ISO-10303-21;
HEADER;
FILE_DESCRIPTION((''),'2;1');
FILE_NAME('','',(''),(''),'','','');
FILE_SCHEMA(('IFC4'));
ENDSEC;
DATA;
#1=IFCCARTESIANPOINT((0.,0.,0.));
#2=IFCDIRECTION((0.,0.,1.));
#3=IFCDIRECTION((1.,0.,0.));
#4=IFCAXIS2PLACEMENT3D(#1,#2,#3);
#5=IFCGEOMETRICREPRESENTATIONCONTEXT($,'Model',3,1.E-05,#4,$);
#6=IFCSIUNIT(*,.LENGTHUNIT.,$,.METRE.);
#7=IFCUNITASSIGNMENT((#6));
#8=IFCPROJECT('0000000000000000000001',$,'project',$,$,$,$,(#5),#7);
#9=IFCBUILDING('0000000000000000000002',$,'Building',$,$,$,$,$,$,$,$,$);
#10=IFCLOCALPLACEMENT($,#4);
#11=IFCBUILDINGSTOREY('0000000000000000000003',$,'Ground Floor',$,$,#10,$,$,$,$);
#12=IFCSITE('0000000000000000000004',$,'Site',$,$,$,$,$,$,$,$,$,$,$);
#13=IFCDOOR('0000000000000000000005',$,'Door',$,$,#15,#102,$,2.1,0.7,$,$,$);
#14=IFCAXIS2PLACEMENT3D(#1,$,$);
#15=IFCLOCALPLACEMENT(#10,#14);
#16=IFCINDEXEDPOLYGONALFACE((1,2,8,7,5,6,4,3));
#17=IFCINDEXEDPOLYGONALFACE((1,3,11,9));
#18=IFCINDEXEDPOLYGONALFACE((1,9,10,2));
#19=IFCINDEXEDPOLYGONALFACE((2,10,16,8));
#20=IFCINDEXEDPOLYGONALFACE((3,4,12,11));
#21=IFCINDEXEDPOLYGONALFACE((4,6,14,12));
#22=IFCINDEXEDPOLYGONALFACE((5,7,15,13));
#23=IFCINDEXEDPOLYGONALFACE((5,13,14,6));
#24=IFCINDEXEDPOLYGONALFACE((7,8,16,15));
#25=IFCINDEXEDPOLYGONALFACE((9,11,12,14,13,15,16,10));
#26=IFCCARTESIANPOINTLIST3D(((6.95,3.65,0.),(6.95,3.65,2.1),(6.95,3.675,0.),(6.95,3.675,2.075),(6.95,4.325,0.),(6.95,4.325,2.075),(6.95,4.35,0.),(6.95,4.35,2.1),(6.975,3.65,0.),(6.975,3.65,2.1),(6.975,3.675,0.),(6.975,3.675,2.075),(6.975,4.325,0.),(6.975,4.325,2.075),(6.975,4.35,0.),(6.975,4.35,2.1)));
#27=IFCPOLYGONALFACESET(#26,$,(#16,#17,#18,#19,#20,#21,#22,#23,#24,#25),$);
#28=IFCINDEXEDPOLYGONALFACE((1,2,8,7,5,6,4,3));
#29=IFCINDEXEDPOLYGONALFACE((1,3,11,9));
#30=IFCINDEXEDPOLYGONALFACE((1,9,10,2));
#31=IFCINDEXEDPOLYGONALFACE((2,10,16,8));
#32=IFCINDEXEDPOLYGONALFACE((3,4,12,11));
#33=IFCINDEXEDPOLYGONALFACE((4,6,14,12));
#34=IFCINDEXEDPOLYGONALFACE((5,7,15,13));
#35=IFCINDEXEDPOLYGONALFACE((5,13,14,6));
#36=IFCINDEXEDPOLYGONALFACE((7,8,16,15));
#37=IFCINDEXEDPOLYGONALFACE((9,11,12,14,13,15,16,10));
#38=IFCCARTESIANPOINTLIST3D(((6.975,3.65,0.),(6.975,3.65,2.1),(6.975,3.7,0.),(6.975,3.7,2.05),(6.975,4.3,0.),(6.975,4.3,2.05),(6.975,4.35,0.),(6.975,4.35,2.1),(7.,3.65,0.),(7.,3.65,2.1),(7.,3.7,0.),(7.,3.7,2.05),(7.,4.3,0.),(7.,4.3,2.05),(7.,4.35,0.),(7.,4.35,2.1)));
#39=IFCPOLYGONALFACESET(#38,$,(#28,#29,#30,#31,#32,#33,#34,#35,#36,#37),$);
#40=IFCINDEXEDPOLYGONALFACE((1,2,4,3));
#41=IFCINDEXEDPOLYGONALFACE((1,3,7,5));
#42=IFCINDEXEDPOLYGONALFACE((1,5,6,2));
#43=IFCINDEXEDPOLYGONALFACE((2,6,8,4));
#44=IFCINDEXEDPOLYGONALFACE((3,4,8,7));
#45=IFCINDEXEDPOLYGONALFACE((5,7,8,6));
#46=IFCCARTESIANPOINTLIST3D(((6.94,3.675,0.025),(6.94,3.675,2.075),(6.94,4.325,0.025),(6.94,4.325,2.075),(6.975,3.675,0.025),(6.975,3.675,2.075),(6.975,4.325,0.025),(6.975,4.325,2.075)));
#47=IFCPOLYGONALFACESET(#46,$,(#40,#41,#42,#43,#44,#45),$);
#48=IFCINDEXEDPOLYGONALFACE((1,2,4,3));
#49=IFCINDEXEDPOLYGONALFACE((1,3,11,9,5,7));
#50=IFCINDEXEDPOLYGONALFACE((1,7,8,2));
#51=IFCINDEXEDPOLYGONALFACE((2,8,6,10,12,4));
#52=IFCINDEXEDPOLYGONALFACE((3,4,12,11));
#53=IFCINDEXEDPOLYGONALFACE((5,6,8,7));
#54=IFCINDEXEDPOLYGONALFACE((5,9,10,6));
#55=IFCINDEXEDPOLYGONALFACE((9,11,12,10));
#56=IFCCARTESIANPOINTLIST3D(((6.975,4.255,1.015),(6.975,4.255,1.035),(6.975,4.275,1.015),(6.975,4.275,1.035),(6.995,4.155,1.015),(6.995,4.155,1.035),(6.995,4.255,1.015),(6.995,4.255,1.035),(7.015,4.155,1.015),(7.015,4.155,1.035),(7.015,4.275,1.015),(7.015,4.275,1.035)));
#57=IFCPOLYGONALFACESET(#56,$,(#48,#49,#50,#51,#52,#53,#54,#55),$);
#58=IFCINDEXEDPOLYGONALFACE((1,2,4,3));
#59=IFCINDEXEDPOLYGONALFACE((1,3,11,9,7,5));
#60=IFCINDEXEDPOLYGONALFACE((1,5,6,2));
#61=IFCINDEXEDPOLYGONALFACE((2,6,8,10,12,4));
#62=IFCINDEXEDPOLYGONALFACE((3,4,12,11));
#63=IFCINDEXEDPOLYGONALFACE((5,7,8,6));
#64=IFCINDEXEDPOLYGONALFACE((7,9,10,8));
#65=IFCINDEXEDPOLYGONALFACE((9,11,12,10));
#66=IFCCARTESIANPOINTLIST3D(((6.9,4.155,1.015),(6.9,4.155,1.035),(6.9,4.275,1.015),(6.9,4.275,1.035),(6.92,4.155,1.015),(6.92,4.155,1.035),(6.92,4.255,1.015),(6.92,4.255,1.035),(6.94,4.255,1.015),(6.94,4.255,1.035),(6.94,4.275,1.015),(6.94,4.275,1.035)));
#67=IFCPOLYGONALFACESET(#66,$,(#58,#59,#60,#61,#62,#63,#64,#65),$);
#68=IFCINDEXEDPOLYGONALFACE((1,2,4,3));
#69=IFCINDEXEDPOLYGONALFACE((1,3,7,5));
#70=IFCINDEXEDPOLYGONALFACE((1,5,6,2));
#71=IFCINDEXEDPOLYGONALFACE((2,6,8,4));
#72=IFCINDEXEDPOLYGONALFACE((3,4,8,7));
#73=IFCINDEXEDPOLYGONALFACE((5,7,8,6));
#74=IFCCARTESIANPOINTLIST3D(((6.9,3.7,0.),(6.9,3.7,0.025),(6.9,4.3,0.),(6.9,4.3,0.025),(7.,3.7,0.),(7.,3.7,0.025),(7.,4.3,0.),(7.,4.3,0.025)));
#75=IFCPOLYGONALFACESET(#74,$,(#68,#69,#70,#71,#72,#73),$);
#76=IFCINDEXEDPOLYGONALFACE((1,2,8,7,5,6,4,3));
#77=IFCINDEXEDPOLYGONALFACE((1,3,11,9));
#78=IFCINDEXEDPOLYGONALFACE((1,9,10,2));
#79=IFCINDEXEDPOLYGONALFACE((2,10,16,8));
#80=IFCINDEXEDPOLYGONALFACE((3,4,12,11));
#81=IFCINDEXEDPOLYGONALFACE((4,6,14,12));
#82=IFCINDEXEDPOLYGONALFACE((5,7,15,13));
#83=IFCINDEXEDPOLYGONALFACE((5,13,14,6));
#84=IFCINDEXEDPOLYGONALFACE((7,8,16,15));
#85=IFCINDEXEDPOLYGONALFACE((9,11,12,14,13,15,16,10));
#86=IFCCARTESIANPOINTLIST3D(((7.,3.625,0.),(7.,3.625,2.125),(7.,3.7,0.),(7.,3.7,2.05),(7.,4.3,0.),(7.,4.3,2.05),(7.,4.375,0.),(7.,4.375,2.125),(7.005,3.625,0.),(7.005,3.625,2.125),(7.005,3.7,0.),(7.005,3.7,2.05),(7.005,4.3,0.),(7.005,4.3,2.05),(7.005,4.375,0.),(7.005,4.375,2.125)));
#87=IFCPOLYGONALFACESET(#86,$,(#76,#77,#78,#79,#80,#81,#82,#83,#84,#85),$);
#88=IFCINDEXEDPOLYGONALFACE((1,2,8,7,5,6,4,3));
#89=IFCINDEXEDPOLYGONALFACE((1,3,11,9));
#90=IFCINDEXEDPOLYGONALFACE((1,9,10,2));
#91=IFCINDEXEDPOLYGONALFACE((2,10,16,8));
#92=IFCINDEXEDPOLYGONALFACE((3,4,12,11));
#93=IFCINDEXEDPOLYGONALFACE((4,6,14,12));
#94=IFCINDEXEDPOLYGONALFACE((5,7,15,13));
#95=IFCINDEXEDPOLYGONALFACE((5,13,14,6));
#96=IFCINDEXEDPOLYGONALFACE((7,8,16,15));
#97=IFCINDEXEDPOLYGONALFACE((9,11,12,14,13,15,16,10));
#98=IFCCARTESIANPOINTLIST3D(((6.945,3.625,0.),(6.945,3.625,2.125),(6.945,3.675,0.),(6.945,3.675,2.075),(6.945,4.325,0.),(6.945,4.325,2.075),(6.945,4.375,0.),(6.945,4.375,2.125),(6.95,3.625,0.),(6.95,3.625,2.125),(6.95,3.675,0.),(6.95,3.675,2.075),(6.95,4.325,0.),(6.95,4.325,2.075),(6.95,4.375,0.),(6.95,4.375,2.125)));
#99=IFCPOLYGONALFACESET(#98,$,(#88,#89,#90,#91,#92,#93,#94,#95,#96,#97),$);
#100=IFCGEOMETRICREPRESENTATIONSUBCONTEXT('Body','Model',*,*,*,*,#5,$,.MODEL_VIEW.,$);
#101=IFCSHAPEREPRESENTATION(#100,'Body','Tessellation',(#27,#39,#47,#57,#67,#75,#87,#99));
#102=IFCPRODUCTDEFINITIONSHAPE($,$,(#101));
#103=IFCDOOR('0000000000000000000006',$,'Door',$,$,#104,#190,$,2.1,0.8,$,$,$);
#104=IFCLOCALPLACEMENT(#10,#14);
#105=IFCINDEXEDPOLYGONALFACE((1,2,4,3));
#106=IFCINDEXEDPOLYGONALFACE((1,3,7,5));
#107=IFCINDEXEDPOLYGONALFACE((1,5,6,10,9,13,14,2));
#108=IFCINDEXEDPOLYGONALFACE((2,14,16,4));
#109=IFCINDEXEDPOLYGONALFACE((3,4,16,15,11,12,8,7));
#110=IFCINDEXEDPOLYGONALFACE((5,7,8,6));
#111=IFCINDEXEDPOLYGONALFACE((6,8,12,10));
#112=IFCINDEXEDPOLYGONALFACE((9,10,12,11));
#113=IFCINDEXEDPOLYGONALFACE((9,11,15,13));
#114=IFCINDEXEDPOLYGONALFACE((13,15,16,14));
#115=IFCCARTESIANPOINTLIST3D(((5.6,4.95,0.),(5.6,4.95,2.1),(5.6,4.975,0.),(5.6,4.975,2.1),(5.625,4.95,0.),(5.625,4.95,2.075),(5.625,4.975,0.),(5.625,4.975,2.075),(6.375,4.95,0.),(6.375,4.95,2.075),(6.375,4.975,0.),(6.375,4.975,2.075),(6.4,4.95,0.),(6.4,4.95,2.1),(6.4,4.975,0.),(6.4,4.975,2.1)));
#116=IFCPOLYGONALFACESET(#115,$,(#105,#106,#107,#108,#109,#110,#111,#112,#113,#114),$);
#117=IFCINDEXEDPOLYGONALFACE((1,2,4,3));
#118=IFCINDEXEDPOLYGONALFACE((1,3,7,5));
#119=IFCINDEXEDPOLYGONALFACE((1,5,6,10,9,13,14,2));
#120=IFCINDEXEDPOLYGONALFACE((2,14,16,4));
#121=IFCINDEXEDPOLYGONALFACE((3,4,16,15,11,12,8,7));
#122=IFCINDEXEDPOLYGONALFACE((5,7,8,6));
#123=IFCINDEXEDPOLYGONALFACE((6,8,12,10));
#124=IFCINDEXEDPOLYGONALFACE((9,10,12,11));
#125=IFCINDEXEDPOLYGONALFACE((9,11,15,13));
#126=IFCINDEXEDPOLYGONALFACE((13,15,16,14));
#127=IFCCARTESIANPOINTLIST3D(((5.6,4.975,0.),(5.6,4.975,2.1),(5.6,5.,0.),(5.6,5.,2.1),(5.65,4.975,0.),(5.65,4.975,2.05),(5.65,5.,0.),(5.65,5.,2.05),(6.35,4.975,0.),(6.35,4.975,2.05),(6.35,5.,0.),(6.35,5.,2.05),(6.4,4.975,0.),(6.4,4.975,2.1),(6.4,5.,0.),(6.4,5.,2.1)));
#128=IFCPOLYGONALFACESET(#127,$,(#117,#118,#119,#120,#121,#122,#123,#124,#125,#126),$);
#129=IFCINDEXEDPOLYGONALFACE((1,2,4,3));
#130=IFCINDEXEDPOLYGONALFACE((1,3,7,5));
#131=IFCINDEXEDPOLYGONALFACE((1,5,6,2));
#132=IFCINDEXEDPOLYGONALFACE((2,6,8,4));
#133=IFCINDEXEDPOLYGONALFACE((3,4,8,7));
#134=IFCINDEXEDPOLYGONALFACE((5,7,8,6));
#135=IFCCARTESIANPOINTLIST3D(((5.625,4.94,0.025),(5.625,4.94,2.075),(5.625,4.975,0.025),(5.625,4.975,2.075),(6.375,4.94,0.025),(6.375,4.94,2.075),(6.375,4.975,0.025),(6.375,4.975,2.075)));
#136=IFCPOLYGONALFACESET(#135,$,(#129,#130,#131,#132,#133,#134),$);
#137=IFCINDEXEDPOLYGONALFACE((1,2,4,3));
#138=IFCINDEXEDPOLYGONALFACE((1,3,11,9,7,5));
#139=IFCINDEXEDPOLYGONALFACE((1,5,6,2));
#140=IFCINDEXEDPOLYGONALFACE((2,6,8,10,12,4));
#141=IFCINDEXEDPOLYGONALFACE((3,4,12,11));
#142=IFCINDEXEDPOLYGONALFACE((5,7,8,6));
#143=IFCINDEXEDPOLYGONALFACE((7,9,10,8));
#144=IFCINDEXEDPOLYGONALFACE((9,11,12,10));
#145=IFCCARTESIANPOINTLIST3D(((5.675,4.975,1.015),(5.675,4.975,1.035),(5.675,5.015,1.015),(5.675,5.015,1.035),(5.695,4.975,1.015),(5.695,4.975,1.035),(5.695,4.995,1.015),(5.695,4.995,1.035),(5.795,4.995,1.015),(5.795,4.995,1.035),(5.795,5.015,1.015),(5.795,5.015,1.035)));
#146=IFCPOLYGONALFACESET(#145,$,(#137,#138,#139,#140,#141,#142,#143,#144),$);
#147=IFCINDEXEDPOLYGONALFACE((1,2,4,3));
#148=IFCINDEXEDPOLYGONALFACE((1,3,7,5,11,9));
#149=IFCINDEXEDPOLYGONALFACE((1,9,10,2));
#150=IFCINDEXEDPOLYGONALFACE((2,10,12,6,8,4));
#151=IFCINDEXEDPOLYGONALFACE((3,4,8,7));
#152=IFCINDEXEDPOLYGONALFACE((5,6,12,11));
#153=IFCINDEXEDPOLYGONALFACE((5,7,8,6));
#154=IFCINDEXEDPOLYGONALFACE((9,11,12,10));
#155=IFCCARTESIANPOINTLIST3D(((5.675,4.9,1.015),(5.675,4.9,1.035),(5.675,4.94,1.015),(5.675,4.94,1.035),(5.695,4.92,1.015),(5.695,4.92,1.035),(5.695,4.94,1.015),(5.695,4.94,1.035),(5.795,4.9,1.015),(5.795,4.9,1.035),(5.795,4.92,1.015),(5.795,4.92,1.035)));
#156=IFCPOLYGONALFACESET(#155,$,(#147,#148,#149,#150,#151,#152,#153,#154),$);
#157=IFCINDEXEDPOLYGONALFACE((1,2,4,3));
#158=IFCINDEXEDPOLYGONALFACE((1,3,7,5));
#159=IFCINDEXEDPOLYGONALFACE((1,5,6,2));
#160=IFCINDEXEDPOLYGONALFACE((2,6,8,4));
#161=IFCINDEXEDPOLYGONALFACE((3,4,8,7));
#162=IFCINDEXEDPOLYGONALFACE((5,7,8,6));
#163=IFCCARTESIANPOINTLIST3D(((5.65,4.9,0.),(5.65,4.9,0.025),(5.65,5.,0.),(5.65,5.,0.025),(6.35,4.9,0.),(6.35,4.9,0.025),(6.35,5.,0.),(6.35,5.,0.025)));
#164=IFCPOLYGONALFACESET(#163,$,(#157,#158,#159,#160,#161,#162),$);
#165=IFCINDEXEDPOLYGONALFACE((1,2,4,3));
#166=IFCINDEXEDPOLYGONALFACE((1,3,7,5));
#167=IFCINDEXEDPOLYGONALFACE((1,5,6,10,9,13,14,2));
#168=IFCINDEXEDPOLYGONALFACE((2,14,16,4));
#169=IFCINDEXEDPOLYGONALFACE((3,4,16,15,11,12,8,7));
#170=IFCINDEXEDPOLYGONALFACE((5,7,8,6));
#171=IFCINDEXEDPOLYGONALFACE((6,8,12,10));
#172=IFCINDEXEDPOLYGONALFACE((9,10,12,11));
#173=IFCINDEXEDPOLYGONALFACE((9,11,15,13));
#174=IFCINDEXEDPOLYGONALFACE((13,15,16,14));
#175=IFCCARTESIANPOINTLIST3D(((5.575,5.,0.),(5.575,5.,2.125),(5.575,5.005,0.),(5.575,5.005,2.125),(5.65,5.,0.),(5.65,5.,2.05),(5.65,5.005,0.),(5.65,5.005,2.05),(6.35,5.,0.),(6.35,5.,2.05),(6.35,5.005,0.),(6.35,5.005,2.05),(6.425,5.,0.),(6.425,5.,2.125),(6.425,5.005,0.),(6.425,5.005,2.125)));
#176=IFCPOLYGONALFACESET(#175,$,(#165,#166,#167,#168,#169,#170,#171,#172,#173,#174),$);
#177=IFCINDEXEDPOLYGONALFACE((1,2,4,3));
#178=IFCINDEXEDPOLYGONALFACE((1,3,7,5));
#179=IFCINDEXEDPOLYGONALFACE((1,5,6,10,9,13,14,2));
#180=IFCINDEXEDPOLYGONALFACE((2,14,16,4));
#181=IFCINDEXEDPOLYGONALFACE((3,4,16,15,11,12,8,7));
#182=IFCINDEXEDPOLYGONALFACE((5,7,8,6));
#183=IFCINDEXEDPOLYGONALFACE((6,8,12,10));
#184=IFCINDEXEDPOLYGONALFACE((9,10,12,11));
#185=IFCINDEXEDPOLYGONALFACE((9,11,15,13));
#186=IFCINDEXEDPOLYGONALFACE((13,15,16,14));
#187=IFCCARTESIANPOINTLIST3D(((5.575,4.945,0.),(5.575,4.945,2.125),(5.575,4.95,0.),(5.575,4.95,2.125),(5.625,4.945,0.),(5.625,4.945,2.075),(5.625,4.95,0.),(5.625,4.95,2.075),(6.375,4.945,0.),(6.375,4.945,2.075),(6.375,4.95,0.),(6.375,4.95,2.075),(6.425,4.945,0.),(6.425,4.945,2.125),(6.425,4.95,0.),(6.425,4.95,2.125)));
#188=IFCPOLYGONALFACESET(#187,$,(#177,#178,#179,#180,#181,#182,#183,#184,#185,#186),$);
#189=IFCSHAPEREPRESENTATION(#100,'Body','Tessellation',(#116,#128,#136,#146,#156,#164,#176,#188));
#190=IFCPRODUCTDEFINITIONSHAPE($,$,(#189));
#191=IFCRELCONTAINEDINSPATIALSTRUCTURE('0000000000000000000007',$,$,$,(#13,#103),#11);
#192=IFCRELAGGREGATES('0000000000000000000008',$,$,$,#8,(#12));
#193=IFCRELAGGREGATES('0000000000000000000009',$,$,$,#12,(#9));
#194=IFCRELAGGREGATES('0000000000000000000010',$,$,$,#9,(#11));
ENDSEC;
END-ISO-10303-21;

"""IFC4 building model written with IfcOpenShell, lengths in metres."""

from ifc_helpers import new_model, si_unit, frame, origin_with_axes, place, context, subcontext, project, spatial, line, indexed_curve, outline, extrude, element, save


model = new_model("IFC4")

# Units and contexts
model_context = context("Model", 3, precision=1e-05, world=origin_with_axes())
body_context = subcontext(model_context, "Body", "Model", "MODEL_VIEW")
ifc_project = project(units=[si_unit("LENGTHUNIT", "METRE")], contexts=[model_context])

# Site, building, storey
site = spatial("IfcSite", under=ifc_project, Name="Site")
building = spatial("IfcBuilding", under=site, Name="Building")
storey_placement = place(None, origin_with_axes())
storey = spatial("IfcBuildingStorey", under=building, at=storey_placement, Name="Ground Floor")

# Doors
door_1_placement = place(storey_placement, frame((7.0, 3.65, 0.0), z_axis=(0.0, 0.0, 1.0), x_axis=(0.0, 1.0, 0.0)))
element("IfcDoor", 1, at=door_1_placement, inside=storey, Name="Door", OverallHeight=2.1, OverallWidth=0.7, context=body_context, shape_type="SweptSolid", body=[
    extrude(outline(indexed_curve([(0.0, 0.0), (0.0, 2.1), (0.7, 2.1), (0.7, 0.0), (0.675, 0.0), (0.675, 2.075), (0.025, 2.075), (0.025, 0.0)], segments=[line(1, 2, 3, 4, 5, 6, 7, 8, 1)])), frame((0.0, 0.025, 0.0), z_axis=(0.0, -1.0, 0.0), x_axis=(1.0, 0.0, 0.0)), (0.0, 0.0, -1.0), 0.025),
    extrude(outline(indexed_curve([(0.0, 0.0), (0.0, 2.1), (0.7, 2.1), (0.7, 0.0), (0.65, 0.0), (0.65, 2.05), (0.05, 2.05), (0.05, 0.0)], segments=[line(1, 2, 3, 4, 5, 6, 7, 8, 1)])), frame((0.0, 0.0, 0.0), z_axis=(0.0, -1.0, 0.0), x_axis=(1.0, 0.0, 0.0)), (0.0, 0.0, -1.0), 0.025),
    extrude(outline(indexed_curve([(0.0, 0.0), (0.65, 0.0), (0.65, 0.035), (0.0, 0.035)], segments=[line(1, 2, 3, 4, 1)])), frame((0.025, 0.025, 0.025), z_axis=(0.0, 0.0, 1.0), x_axis=(1.0, 0.0, 0.0)), (0.0, 0.0, 1.0), 2.05),
    extrude(outline(indexed_curve([(0.0, 0.0), (0.0, -0.04), (-0.12, -0.04), (-0.12, -0.02), (-0.02, -0.02), (-0.02, 0.0)], segments=[line(1, 2, 3, 4, 5, 6, 1)])), frame((0.625, 0.025, 1.015), z_axis=(0.0, 0.0, 1.0), x_axis=(1.0, 0.0, 0.0)), (0.0, 0.0, 1.0), 0.02),
    extrude(outline(indexed_curve([(0.0, 0.0), (0.0, 0.04), (-0.12, 0.04), (-0.12, 0.02), (-0.02, 0.02), (-0.02, 0.0)], segments=[line(1, 2, 3, 4, 5, 6, 1)])), frame((0.625, 0.06, 1.015), z_axis=(0.0, 0.0, 1.0), x_axis=(1.0, 0.0, 0.0)), (0.0, 0.0, 1.0), 0.02),
    extrude(outline(indexed_curve([(0.0, 0.0), (0.6, 0.0), (0.6, 0.1), (0.0, 0.1)], segments=[line(1, 2, 3, 4, 1)])), frame((0.05, 0.0, 0.0), z_axis=(0.0, 0.0, 1.0), x_axis=(1.0, 0.0, 0.0)), (0.0, 0.0, 1.0), 0.025),
    extrude(outline(indexed_curve([(0.0, 0.0), (0.0, 2.125), (0.75, 2.125), (0.75, 0.0), (0.675, 0.0), (0.675, 2.05), (0.075, 2.05), (0.075, 0.0)], segments=[line(1, 2, 3, 4, 5, 6, 7, 8, 1)])), frame((-0.025, -0.005, 0.0), z_axis=(0.0, -1.0, 0.0), x_axis=(1.0, 0.0, 0.0)), (0.0, 0.0, -1.0), 0.005),
    extrude(outline(indexed_curve([(0.0, 0.0), (0.0, 2.125), (0.75, 2.125), (0.75, 0.0), (0.7, 0.0), (0.7, 2.075), (0.05, 2.075), (0.05, 0.0)], segments=[line(1, 2, 3, 4, 5, 6, 7, 8, 1)])), frame((-0.025, 0.05, 0.0), z_axis=(0.0, -1.0, 0.0), x_axis=(1.0, 0.0, 0.0)), (0.0, 0.0, -1.0), 0.005),
])
door_2_placement = place(storey_placement, frame((6.4, 5.0, 0.0), z_axis=(0.0, 0.0, 1.0), x_axis=(-1.0, 0.0, 0.0)))
element("IfcDoor", 2, at=door_2_placement, inside=storey, Name="Door", OverallHeight=2.1, OverallWidth=0.8, context=body_context, shape_type="SweptSolid", body=[
    extrude(outline(indexed_curve([(0.0, 0.0), (0.0, 2.1), (0.8, 2.1), (0.8, 0.0), (0.775, 0.0), (0.775, 2.075), (0.025, 2.075), (0.025, 0.0)], segments=[line(1, 2, 3, 4, 5, 6, 7, 8, 1)])), frame((0.0, 0.025, 0.0), z_axis=(0.0, -1.0, 0.0), x_axis=(1.0, 0.0, 0.0)), (0.0, 0.0, -1.0), 0.025),
    extrude(outline(indexed_curve([(0.0, 0.0), (0.0, 2.1), (0.8, 2.1), (0.8, 0.0), (0.75, 0.0), (0.75, 2.05), (0.05, 2.05), (0.05, 0.0)], segments=[line(1, 2, 3, 4, 5, 6, 7, 8, 1)])), frame((0.0, 0.0, 0.0), z_axis=(0.0, -1.0, 0.0), x_axis=(1.0, 0.0, 0.0)), (0.0, 0.0, -1.0), 0.025),
    extrude(outline(indexed_curve([(0.0, 0.0), (0.75, 0.0), (0.75, 0.035), (0.0, 0.035)], segments=[line(1, 2, 3, 4, 1)])), frame((0.025, 0.025, 0.025), z_axis=(0.0, 0.0, 1.0), x_axis=(1.0, 0.0, 0.0)), (0.0, 0.0, 1.0), 2.05),
    extrude(outline(indexed_curve([(0.0, 0.0), (0.0, -0.04), (-0.12, -0.04), (-0.12, -0.02), (-0.02, -0.02), (-0.02, 0.0)], segments=[line(1, 2, 3, 4, 5, 6, 1)])), frame((0.725, 0.025, 1.015), z_axis=(0.0, 0.0, 1.0), x_axis=(1.0, 0.0, 0.0)), (0.0, 0.0, 1.0), 0.02),
    extrude(outline(indexed_curve([(0.0, 0.0), (0.0, 0.04), (-0.12, 0.04), (-0.12, 0.02), (-0.02, 0.02), (-0.02, 0.0)], segments=[line(1, 2, 3, 4, 5, 6, 1)])), frame((0.725, 0.06, 1.015), z_axis=(0.0, 0.0, 1.0), x_axis=(1.0, 0.0, 0.0)), (0.0, 0.0, 1.0), 0.02),
    extrude(outline(indexed_curve([(0.0, 0.0), (0.7, 0.0), (0.7, 0.1), (0.0, 0.1)], segments=[line(1, 2, 3, 4, 1)])), frame((0.05, 0.0, 0.0), z_axis=(0.0, 0.0, 1.0), x_axis=(1.0, 0.0, 0.0)), (0.0, 0.0, 1.0), 0.025),
    extrude(outline(indexed_curve([(0.0, 0.0), (0.0, 2.125), (0.85, 2.125), (0.85, 0.0), (0.775, 0.0), (0.775, 2.05), (0.075, 2.05), (0.075, 0.0)], segments=[line(1, 2, 3, 4, 5, 6, 7, 8, 1)])), frame((-0.025, -0.005, 0.0), z_axis=(0.0, -1.0, 0.0), x_axis=(1.0, 0.0, 0.0)), (0.0, 0.0, -1.0), 0.005),
    extrude(outline(indexed_curve([(0.0, 0.0), (0.0, 2.125), (0.85, 2.125), (0.85, 0.0), (0.8, 0.0), (0.8, 2.075), (0.05, 2.075), (0.05, 0.0)], segments=[line(1, 2, 3, 4, 5, 6, 7, 8, 1)])), frame((-0.025, 0.05, 0.0), z_axis=(0.0, -1.0, 0.0), x_axis=(1.0, 0.0, 0.0)), (0.0, 0.0, -1.0), 0.005),
])

save(model, "model.ifc")
